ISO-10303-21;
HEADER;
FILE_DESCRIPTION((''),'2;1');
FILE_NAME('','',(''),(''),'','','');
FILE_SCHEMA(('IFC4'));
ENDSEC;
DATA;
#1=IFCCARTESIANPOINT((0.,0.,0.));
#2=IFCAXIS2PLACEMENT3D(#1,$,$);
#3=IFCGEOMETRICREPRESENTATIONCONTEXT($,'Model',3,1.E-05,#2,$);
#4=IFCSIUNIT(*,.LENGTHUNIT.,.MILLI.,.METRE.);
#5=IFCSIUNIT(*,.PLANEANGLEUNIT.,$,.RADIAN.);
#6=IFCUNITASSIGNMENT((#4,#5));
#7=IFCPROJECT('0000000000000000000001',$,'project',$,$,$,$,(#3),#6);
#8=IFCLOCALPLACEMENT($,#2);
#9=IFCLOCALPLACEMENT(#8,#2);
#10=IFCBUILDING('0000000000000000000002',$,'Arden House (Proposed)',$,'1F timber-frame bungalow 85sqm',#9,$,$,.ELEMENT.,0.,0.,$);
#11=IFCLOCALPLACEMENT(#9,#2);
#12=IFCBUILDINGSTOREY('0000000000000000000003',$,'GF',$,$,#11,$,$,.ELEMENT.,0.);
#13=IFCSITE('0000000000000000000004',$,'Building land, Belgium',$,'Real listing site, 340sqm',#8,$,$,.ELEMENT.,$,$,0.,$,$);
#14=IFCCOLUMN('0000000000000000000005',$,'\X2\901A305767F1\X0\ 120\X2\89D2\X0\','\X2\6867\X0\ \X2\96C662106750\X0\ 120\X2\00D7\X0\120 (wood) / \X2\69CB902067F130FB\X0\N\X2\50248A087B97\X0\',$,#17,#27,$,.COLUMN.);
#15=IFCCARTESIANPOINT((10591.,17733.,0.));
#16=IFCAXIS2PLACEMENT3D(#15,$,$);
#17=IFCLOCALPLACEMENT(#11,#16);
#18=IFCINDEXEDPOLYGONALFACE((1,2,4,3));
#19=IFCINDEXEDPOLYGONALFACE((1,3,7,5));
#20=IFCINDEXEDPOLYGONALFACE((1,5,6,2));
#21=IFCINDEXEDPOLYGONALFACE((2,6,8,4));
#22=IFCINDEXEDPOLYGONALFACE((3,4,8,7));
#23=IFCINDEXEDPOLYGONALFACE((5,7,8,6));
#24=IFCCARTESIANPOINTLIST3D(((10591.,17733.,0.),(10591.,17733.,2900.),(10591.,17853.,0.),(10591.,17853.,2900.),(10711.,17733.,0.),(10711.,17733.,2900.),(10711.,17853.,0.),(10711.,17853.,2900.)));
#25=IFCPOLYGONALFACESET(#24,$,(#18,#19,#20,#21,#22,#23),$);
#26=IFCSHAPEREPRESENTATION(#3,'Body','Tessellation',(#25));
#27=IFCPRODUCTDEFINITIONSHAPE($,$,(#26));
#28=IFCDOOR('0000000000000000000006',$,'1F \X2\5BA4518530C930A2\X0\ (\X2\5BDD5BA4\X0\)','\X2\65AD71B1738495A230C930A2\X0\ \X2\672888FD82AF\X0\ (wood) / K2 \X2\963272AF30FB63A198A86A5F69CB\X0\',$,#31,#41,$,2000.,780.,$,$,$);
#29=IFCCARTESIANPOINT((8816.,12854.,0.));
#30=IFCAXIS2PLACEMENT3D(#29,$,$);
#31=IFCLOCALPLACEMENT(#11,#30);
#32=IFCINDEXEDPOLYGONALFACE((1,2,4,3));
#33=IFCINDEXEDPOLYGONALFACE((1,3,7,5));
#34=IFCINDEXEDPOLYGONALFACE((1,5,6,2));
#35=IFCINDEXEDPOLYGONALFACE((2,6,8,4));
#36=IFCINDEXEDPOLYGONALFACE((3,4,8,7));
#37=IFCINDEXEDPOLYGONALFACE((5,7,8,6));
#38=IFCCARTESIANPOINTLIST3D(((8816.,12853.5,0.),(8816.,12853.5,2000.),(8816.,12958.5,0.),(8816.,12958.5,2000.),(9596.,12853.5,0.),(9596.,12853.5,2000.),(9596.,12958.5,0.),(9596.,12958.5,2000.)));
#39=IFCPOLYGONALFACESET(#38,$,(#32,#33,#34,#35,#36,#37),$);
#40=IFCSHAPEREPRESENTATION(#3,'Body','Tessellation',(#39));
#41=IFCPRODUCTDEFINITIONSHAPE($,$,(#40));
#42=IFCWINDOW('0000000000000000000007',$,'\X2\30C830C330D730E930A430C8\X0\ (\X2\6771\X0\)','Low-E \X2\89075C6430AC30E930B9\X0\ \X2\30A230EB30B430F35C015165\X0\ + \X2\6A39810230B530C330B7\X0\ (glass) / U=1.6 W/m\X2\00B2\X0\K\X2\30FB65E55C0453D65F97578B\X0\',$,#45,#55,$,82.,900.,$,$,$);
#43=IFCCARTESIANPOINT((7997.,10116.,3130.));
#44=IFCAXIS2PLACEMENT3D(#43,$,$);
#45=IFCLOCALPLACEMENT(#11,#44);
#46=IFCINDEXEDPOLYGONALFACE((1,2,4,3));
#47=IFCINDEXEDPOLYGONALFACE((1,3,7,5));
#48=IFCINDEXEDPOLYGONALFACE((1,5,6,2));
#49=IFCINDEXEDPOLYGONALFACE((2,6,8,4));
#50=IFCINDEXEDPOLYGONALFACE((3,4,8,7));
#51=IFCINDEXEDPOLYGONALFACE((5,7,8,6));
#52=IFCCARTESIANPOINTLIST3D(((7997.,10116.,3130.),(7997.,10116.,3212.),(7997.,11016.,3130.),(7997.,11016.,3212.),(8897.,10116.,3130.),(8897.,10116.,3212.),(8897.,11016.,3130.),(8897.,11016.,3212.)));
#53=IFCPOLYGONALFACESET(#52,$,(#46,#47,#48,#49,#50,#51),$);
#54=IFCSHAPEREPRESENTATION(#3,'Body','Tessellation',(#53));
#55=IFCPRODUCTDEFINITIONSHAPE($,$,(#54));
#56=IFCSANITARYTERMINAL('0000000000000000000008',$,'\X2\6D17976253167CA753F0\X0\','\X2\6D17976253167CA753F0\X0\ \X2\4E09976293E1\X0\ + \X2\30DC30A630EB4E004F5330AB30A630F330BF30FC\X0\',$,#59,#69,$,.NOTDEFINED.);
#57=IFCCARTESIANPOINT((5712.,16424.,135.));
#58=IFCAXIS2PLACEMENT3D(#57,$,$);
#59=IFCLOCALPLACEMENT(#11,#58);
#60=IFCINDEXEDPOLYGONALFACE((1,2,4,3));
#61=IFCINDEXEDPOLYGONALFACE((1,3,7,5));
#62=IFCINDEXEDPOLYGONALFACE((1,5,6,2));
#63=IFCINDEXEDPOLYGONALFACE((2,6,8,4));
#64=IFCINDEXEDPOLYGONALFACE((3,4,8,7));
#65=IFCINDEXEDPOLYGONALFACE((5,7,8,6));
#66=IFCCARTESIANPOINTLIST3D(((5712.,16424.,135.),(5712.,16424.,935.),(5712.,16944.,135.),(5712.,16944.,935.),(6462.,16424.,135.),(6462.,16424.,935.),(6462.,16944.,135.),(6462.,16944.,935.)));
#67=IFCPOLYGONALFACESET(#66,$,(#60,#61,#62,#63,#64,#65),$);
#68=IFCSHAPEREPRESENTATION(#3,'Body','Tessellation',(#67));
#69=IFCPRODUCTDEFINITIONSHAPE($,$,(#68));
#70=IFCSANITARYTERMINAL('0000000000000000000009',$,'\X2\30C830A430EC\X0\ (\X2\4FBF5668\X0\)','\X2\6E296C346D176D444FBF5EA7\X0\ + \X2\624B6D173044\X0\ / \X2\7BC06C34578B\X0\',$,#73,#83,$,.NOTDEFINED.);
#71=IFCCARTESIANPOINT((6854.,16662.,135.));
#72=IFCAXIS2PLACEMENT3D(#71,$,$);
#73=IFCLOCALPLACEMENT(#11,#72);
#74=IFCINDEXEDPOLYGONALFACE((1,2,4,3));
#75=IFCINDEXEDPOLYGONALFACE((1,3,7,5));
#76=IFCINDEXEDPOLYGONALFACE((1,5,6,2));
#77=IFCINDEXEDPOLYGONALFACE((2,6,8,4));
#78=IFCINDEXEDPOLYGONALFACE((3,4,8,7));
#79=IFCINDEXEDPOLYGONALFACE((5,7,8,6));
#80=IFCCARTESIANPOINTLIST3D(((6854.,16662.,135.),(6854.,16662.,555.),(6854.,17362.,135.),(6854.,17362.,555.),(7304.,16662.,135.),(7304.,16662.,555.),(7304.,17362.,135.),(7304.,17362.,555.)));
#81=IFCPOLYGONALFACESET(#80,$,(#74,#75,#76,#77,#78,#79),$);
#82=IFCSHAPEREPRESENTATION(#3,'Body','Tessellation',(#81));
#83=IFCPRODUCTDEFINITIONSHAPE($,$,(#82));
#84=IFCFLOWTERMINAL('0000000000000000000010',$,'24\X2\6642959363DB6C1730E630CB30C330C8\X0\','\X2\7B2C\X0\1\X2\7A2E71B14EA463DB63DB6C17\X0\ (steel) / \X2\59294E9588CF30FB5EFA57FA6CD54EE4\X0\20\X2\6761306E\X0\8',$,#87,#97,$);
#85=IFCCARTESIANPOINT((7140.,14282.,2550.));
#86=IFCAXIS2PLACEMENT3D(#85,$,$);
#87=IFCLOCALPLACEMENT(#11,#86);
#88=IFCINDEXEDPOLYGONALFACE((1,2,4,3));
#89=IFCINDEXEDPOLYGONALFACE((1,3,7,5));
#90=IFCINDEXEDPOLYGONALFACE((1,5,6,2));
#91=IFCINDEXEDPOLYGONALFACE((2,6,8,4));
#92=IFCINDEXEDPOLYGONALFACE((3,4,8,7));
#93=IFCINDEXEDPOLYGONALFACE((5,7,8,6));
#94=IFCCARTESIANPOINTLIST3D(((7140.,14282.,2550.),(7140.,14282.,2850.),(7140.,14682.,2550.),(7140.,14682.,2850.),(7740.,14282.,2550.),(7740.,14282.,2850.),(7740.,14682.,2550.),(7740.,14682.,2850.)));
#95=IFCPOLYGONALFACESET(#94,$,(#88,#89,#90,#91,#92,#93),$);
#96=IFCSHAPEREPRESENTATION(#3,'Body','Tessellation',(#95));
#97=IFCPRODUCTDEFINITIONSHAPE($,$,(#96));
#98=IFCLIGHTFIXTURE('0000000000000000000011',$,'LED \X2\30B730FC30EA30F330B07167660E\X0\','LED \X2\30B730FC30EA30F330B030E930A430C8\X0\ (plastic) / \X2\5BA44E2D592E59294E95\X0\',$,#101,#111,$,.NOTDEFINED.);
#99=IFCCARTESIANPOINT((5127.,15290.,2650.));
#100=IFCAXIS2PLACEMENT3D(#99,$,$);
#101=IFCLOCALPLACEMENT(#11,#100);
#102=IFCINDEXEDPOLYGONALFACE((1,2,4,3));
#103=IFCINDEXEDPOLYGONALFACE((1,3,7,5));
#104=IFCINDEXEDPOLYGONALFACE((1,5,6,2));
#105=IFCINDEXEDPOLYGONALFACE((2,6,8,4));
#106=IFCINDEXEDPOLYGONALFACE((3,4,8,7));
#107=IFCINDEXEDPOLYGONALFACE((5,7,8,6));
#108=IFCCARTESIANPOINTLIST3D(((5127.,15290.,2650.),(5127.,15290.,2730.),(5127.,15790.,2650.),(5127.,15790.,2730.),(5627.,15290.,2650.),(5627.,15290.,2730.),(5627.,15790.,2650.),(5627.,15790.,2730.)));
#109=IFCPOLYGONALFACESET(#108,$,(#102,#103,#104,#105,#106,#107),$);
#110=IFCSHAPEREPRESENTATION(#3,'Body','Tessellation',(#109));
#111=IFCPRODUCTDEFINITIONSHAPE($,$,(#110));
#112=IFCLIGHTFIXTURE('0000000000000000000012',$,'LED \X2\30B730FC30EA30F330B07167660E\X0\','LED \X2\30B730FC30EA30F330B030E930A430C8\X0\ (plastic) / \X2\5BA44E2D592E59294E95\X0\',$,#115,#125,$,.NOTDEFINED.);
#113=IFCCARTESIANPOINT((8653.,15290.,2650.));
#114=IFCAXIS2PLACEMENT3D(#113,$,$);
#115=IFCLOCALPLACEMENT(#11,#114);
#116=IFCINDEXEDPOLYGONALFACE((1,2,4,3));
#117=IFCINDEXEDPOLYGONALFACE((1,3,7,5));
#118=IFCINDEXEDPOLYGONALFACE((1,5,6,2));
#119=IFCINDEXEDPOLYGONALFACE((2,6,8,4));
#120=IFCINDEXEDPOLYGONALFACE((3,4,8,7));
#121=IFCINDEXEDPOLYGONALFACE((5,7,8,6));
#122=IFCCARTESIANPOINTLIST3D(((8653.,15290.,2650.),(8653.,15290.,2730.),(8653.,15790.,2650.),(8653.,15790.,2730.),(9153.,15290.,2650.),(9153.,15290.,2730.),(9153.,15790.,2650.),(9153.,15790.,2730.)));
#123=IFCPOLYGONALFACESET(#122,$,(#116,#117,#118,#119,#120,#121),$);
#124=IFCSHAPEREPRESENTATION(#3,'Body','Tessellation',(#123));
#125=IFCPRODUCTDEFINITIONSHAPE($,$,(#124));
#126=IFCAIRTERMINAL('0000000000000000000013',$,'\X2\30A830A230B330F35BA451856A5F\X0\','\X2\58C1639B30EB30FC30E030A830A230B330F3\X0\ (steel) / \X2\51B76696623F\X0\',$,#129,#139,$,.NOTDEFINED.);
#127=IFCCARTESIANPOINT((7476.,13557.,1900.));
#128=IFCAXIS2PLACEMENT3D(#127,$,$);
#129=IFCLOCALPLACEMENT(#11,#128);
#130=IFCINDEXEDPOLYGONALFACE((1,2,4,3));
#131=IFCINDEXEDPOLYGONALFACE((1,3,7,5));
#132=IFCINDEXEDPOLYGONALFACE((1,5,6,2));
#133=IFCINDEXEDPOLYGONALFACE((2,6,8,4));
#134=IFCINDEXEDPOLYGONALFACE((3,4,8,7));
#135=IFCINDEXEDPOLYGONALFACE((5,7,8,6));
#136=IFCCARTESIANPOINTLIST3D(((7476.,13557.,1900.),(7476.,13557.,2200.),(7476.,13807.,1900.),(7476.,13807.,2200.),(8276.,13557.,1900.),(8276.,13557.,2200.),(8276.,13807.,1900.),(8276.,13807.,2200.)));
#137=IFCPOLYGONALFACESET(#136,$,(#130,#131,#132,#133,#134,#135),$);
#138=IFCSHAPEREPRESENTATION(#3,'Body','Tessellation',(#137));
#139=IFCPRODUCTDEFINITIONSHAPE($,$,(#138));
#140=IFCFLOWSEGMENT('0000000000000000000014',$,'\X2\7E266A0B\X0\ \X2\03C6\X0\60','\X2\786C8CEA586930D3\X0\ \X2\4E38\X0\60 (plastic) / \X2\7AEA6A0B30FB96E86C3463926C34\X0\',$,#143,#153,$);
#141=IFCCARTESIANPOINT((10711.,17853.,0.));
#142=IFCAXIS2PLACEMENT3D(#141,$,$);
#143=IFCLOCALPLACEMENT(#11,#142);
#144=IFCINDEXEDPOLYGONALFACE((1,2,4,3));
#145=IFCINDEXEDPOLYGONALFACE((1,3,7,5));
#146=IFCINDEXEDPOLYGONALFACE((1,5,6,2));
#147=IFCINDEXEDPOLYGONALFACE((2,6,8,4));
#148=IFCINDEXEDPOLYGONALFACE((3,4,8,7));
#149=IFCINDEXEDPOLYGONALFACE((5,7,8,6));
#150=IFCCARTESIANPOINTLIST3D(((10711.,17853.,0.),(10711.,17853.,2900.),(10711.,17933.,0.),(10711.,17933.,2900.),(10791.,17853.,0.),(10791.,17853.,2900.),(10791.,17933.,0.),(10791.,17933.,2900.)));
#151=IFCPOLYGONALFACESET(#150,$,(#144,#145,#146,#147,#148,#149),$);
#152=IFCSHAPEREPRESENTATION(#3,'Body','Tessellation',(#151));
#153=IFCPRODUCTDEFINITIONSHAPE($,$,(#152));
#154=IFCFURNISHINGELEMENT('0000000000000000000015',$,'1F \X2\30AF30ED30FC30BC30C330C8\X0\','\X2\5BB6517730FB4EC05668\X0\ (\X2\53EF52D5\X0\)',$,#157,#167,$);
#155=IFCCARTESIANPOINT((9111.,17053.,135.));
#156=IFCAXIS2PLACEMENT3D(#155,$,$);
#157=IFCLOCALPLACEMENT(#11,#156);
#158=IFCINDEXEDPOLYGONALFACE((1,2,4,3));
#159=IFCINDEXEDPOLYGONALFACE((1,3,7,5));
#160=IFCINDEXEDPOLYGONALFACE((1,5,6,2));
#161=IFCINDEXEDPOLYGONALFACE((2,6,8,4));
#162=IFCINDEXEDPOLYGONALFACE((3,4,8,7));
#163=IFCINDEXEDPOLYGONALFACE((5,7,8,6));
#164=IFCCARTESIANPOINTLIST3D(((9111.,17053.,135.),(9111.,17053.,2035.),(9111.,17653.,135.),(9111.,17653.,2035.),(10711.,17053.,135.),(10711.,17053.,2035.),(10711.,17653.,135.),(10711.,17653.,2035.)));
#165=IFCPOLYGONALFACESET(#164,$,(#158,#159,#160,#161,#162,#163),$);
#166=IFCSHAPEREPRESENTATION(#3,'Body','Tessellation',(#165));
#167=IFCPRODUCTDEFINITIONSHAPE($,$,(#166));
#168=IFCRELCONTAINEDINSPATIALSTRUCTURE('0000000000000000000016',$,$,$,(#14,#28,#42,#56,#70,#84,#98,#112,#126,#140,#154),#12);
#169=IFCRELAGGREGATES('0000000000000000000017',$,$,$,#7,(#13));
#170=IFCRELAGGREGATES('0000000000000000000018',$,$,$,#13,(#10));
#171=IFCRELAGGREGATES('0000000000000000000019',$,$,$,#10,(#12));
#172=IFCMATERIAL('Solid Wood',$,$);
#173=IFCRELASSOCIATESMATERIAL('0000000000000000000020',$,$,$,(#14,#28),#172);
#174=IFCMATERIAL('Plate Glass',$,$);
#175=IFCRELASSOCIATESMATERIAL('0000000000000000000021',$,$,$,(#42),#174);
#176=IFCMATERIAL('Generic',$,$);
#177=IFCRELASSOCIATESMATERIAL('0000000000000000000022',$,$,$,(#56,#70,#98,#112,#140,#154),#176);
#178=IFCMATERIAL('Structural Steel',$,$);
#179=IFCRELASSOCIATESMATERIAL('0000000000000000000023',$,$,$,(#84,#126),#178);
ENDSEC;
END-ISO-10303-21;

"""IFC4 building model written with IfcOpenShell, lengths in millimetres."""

from ifc_helpers import new_model, si_unit, frame, frame_2d, origin, place, context, project, spatial, rectangle, extrude, material, element, save


model = new_model("IFC4")

# Units and contexts
model_context = context("Model", 3, precision=1e-05, world=origin())
ifc_project = project(units=[si_unit("LENGTHUNIT", "METRE", prefix="MILLI"), si_unit("PLANEANGLEUNIT", "RADIAN")], contexts=[model_context])

# Site, building, storey
site_placement = place(None, origin())
site = spatial("IfcSite", under=ifc_project, at=site_placement, Name="Building land, Belgium", ObjectType="Real listing site, 340sqm", CompositionType="ELEMENT", RefElevation=0.0)
building_placement = place(site_placement, origin())
building = spatial("IfcBuilding", under=site, at=building_placement, Name="Arden House (Proposed)", ObjectType="1F timber-frame bungalow 85sqm", CompositionType="ELEMENT", ElevationOfRefHeight=0.0, ElevationOfTerrain=0.0)
storey_placement = place(building_placement, origin())
storey = spatial("IfcBuildingStorey", under=building, at=storey_placement, Name="GF", CompositionType="ELEMENT", Elevation=0.0)

# Column
ifc_material_1 = material(Name="Solid Wood")
column_1_placement = place(storey_placement, frame((10591.0, 17733.0, 0.0)))
element("IfcColumn", 1, at=column_1_placement, inside=storey, material=ifc_material_1, Name="通し柱 120角", Description="桧 集成材 120×120 (wood) / 構造柱・N値計算", PredefinedType="COLUMN", context=model_context, shape_type="SweptSolid", body=[
    extrude(rectangle(XDim=120.0, YDim=120.0, at=frame_2d((60.0, 60.0))), frame((10591.0, 17733.0, 0.0)), (0.0, 0.0, 1.0), 2900.0),
])

# Door
door_placement = place(storey_placement, frame((8816.0, 12854.0, 0.0)))
element("IfcDoor", 2, at=door_placement, inside=storey, material=ifc_material_1, Name="1F 室内ドア (寝室)", Description="断熱玄関ドア 木製芯 (wood) / K2 防犯・採風機構", OverallHeight=2000.0, OverallWidth=780.0, context=model_context, shape_type="SweptSolid", body=[
    extrude(rectangle(XDim=780.0, YDim=105.0, at=frame_2d((390.0, 52.0))), frame((8816.0, 12854.0, 0.0)), (0.0, 0.0, 1.0), 2000.0),
])

# Window
ifc_material_2 = material(Name="Plate Glass")
window_placement = place(storey_placement, frame((7997.0, 10116.0, 3130.0)))
element("IfcWindow", 3, at=window_placement, inside=storey, material=ifc_material_2, Name="トップライト (東)", Description="Low-E 複層ガラス アルゴン封入 + 樹脂サッシ (glass) / U=1.6 W/m²K・日射取得型", OverallHeight=82.0, OverallWidth=900.0, context=model_context, shape_type="SweptSolid", body=[
    extrude(rectangle(XDim=900.0, YDim=900.0, at=frame_2d((450.0, 450.0))), frame((7997.0, 10116.0, 3130.0)), (0.0, 0.0, 1.0), 82.0),
])

# Sanitary terminals
ifc_material_3 = material(Name="Generic")
sanitary_terminal_1_placement = place(storey_placement, frame((5712.0, 16424.0, 135.0)))
element("IfcSanitaryTerminal", 4, at=sanitary_terminal_1_placement, inside=storey, material=ifc_material_3, Name="洗面化粧台", Description="洗面化粧台 三面鏡 + ボウル一体カウンター", PredefinedType="NOTDEFINED", context=model_context, shape_type="SweptSolid", body=[
    extrude(rectangle(XDim=750.0, YDim=520.0, at=frame_2d((375.0, 260.0))), frame((5712.0, 16424.0, 135.0)), (0.0, 0.0, 1.0), 800.0),
])
sanitary_terminal_2_placement = place(storey_placement, frame((6854.0, 16662.0, 135.0)))
element("IfcSanitaryTerminal", 5, at=sanitary_terminal_2_placement, inside=storey, material=ifc_material_3, Name="トイレ (便器)", Description="温水洗浄便座 + 手洗い / 節水型", PredefinedType="NOTDEFINED", context=model_context, shape_type="SweptSolid", body=[
    extrude(rectangle(XDim=450.0, YDim=700.0, at=frame_2d((225.0, 350.0))), frame((6854.0, 16662.0, 135.0)), (0.0, 0.0, 1.0), 420.0),
])

# Flow terminal
ifc_material_4 = material(Name="Structural Steel")
flow_terminal_placement = place(storey_placement, frame((7140.0, 14282.0, 2550.0)))
element("IfcFlowTerminal", 6, at=flow_terminal_placement, inside=storey, material=ifc_material_4, Name="24時間換気ユニット", Description="第1種熱交換換気 (steel) / 天井裏・建基法令20条の8", context=model_context, shape_type="SweptSolid", body=[
    extrude(rectangle(XDim=600.0, YDim=400.0, at=frame_2d((300.0, 200.0))), frame((7140.0, 14282.0, 2550.0)), (0.0, 0.0, 1.0), 300.0),
])

# Light fixtures
light_fixture_1_placement = place(storey_placement, frame((5127.0, 15290.0, 2650.0)))
element("IfcLightFixture", 7, at=light_fixture_1_placement, inside=storey, material=ifc_material_3, Name="LED シーリング照明", Description="LED シーリングライト (plastic) / 室中央天井", PredefinedType="NOTDEFINED", context=model_context, shape_type="SweptSolid", body=[
    extrude(rectangle(XDim=500.0, YDim=500.0, at=frame_2d((250.0, 250.0))), frame((5127.0, 15290.0, 2650.0)), (0.0, 0.0, 1.0), 80.0),
])
light_fixture_2_placement = place(storey_placement, frame((8653.0, 15290.0, 2650.0)))
element("IfcLightFixture", 8, at=light_fixture_2_placement, inside=storey, material=ifc_material_3, Name="LED シーリング照明", Description="LED シーリングライト (plastic) / 室中央天井", PredefinedType="NOTDEFINED", context=model_context, shape_type="SweptSolid", body=[
    extrude(rectangle(XDim=500.0, YDim=500.0, at=frame_2d((250.0, 250.0))), frame((8653.0, 15290.0, 2650.0)), (0.0, 0.0, 1.0), 80.0),
])

# Air terminal
air_terminal_placement = place(storey_placement, frame((7476.0, 13557.0, 1900.0)))
element("IfcAirTerminal", 9, at=air_terminal_placement, inside=storey, material=ifc_material_4, Name="エアコン室内機", Description="壁掛ルームエアコン (steel) / 冷暖房", PredefinedType="NOTDEFINED", context=model_context, shape_type="SweptSolid", body=[
    extrude(rectangle(XDim=800.0, YDim=250.0, at=frame_2d((400.0, 125.0))), frame((7476.0, 13557.0, 1900.0)), (0.0, 0.0, 1.0), 300.0),
])

# Flow segment
flow_segment_placement = place(storey_placement, frame((10711.0, 17853.0, 0.0)))
element("IfcFlowSegment", 10, at=flow_segment_placement, inside=storey, material=ifc_material_3, Name="縦樋 φ60", Description="硬質塩ビ 丸60 (plastic) / 竪樋・雨水排水", context=model_context, shape_type="SweptSolid", body=[
    extrude(rectangle(XDim=80.0, YDim=80.0, at=frame_2d((40.0, 40.0))), frame((10711.0, 17853.0, 0.0)), (0.0, 0.0, 1.0), 2900.0),
])

# Furnishing element
furnishing_placement = place(storey_placement, frame((9111.0, 17053.0, 135.0)))
element("IfcFurnishingElement", 11, at=furnishing_placement, inside=storey, material=ifc_material_3, Name="1F クローゼット", Description="家具・什器 (可動)", context=model_context, shape_type="SweptSolid", body=[
    extrude(rectangle(XDim=1600.0, YDim=600.0, at=frame_2d((800.0, 300.0))), frame((9111.0, 17053.0, 135.0)), (0.0, 0.0, 1.0), 1900.0),
])

save(model, "model.ifc")
